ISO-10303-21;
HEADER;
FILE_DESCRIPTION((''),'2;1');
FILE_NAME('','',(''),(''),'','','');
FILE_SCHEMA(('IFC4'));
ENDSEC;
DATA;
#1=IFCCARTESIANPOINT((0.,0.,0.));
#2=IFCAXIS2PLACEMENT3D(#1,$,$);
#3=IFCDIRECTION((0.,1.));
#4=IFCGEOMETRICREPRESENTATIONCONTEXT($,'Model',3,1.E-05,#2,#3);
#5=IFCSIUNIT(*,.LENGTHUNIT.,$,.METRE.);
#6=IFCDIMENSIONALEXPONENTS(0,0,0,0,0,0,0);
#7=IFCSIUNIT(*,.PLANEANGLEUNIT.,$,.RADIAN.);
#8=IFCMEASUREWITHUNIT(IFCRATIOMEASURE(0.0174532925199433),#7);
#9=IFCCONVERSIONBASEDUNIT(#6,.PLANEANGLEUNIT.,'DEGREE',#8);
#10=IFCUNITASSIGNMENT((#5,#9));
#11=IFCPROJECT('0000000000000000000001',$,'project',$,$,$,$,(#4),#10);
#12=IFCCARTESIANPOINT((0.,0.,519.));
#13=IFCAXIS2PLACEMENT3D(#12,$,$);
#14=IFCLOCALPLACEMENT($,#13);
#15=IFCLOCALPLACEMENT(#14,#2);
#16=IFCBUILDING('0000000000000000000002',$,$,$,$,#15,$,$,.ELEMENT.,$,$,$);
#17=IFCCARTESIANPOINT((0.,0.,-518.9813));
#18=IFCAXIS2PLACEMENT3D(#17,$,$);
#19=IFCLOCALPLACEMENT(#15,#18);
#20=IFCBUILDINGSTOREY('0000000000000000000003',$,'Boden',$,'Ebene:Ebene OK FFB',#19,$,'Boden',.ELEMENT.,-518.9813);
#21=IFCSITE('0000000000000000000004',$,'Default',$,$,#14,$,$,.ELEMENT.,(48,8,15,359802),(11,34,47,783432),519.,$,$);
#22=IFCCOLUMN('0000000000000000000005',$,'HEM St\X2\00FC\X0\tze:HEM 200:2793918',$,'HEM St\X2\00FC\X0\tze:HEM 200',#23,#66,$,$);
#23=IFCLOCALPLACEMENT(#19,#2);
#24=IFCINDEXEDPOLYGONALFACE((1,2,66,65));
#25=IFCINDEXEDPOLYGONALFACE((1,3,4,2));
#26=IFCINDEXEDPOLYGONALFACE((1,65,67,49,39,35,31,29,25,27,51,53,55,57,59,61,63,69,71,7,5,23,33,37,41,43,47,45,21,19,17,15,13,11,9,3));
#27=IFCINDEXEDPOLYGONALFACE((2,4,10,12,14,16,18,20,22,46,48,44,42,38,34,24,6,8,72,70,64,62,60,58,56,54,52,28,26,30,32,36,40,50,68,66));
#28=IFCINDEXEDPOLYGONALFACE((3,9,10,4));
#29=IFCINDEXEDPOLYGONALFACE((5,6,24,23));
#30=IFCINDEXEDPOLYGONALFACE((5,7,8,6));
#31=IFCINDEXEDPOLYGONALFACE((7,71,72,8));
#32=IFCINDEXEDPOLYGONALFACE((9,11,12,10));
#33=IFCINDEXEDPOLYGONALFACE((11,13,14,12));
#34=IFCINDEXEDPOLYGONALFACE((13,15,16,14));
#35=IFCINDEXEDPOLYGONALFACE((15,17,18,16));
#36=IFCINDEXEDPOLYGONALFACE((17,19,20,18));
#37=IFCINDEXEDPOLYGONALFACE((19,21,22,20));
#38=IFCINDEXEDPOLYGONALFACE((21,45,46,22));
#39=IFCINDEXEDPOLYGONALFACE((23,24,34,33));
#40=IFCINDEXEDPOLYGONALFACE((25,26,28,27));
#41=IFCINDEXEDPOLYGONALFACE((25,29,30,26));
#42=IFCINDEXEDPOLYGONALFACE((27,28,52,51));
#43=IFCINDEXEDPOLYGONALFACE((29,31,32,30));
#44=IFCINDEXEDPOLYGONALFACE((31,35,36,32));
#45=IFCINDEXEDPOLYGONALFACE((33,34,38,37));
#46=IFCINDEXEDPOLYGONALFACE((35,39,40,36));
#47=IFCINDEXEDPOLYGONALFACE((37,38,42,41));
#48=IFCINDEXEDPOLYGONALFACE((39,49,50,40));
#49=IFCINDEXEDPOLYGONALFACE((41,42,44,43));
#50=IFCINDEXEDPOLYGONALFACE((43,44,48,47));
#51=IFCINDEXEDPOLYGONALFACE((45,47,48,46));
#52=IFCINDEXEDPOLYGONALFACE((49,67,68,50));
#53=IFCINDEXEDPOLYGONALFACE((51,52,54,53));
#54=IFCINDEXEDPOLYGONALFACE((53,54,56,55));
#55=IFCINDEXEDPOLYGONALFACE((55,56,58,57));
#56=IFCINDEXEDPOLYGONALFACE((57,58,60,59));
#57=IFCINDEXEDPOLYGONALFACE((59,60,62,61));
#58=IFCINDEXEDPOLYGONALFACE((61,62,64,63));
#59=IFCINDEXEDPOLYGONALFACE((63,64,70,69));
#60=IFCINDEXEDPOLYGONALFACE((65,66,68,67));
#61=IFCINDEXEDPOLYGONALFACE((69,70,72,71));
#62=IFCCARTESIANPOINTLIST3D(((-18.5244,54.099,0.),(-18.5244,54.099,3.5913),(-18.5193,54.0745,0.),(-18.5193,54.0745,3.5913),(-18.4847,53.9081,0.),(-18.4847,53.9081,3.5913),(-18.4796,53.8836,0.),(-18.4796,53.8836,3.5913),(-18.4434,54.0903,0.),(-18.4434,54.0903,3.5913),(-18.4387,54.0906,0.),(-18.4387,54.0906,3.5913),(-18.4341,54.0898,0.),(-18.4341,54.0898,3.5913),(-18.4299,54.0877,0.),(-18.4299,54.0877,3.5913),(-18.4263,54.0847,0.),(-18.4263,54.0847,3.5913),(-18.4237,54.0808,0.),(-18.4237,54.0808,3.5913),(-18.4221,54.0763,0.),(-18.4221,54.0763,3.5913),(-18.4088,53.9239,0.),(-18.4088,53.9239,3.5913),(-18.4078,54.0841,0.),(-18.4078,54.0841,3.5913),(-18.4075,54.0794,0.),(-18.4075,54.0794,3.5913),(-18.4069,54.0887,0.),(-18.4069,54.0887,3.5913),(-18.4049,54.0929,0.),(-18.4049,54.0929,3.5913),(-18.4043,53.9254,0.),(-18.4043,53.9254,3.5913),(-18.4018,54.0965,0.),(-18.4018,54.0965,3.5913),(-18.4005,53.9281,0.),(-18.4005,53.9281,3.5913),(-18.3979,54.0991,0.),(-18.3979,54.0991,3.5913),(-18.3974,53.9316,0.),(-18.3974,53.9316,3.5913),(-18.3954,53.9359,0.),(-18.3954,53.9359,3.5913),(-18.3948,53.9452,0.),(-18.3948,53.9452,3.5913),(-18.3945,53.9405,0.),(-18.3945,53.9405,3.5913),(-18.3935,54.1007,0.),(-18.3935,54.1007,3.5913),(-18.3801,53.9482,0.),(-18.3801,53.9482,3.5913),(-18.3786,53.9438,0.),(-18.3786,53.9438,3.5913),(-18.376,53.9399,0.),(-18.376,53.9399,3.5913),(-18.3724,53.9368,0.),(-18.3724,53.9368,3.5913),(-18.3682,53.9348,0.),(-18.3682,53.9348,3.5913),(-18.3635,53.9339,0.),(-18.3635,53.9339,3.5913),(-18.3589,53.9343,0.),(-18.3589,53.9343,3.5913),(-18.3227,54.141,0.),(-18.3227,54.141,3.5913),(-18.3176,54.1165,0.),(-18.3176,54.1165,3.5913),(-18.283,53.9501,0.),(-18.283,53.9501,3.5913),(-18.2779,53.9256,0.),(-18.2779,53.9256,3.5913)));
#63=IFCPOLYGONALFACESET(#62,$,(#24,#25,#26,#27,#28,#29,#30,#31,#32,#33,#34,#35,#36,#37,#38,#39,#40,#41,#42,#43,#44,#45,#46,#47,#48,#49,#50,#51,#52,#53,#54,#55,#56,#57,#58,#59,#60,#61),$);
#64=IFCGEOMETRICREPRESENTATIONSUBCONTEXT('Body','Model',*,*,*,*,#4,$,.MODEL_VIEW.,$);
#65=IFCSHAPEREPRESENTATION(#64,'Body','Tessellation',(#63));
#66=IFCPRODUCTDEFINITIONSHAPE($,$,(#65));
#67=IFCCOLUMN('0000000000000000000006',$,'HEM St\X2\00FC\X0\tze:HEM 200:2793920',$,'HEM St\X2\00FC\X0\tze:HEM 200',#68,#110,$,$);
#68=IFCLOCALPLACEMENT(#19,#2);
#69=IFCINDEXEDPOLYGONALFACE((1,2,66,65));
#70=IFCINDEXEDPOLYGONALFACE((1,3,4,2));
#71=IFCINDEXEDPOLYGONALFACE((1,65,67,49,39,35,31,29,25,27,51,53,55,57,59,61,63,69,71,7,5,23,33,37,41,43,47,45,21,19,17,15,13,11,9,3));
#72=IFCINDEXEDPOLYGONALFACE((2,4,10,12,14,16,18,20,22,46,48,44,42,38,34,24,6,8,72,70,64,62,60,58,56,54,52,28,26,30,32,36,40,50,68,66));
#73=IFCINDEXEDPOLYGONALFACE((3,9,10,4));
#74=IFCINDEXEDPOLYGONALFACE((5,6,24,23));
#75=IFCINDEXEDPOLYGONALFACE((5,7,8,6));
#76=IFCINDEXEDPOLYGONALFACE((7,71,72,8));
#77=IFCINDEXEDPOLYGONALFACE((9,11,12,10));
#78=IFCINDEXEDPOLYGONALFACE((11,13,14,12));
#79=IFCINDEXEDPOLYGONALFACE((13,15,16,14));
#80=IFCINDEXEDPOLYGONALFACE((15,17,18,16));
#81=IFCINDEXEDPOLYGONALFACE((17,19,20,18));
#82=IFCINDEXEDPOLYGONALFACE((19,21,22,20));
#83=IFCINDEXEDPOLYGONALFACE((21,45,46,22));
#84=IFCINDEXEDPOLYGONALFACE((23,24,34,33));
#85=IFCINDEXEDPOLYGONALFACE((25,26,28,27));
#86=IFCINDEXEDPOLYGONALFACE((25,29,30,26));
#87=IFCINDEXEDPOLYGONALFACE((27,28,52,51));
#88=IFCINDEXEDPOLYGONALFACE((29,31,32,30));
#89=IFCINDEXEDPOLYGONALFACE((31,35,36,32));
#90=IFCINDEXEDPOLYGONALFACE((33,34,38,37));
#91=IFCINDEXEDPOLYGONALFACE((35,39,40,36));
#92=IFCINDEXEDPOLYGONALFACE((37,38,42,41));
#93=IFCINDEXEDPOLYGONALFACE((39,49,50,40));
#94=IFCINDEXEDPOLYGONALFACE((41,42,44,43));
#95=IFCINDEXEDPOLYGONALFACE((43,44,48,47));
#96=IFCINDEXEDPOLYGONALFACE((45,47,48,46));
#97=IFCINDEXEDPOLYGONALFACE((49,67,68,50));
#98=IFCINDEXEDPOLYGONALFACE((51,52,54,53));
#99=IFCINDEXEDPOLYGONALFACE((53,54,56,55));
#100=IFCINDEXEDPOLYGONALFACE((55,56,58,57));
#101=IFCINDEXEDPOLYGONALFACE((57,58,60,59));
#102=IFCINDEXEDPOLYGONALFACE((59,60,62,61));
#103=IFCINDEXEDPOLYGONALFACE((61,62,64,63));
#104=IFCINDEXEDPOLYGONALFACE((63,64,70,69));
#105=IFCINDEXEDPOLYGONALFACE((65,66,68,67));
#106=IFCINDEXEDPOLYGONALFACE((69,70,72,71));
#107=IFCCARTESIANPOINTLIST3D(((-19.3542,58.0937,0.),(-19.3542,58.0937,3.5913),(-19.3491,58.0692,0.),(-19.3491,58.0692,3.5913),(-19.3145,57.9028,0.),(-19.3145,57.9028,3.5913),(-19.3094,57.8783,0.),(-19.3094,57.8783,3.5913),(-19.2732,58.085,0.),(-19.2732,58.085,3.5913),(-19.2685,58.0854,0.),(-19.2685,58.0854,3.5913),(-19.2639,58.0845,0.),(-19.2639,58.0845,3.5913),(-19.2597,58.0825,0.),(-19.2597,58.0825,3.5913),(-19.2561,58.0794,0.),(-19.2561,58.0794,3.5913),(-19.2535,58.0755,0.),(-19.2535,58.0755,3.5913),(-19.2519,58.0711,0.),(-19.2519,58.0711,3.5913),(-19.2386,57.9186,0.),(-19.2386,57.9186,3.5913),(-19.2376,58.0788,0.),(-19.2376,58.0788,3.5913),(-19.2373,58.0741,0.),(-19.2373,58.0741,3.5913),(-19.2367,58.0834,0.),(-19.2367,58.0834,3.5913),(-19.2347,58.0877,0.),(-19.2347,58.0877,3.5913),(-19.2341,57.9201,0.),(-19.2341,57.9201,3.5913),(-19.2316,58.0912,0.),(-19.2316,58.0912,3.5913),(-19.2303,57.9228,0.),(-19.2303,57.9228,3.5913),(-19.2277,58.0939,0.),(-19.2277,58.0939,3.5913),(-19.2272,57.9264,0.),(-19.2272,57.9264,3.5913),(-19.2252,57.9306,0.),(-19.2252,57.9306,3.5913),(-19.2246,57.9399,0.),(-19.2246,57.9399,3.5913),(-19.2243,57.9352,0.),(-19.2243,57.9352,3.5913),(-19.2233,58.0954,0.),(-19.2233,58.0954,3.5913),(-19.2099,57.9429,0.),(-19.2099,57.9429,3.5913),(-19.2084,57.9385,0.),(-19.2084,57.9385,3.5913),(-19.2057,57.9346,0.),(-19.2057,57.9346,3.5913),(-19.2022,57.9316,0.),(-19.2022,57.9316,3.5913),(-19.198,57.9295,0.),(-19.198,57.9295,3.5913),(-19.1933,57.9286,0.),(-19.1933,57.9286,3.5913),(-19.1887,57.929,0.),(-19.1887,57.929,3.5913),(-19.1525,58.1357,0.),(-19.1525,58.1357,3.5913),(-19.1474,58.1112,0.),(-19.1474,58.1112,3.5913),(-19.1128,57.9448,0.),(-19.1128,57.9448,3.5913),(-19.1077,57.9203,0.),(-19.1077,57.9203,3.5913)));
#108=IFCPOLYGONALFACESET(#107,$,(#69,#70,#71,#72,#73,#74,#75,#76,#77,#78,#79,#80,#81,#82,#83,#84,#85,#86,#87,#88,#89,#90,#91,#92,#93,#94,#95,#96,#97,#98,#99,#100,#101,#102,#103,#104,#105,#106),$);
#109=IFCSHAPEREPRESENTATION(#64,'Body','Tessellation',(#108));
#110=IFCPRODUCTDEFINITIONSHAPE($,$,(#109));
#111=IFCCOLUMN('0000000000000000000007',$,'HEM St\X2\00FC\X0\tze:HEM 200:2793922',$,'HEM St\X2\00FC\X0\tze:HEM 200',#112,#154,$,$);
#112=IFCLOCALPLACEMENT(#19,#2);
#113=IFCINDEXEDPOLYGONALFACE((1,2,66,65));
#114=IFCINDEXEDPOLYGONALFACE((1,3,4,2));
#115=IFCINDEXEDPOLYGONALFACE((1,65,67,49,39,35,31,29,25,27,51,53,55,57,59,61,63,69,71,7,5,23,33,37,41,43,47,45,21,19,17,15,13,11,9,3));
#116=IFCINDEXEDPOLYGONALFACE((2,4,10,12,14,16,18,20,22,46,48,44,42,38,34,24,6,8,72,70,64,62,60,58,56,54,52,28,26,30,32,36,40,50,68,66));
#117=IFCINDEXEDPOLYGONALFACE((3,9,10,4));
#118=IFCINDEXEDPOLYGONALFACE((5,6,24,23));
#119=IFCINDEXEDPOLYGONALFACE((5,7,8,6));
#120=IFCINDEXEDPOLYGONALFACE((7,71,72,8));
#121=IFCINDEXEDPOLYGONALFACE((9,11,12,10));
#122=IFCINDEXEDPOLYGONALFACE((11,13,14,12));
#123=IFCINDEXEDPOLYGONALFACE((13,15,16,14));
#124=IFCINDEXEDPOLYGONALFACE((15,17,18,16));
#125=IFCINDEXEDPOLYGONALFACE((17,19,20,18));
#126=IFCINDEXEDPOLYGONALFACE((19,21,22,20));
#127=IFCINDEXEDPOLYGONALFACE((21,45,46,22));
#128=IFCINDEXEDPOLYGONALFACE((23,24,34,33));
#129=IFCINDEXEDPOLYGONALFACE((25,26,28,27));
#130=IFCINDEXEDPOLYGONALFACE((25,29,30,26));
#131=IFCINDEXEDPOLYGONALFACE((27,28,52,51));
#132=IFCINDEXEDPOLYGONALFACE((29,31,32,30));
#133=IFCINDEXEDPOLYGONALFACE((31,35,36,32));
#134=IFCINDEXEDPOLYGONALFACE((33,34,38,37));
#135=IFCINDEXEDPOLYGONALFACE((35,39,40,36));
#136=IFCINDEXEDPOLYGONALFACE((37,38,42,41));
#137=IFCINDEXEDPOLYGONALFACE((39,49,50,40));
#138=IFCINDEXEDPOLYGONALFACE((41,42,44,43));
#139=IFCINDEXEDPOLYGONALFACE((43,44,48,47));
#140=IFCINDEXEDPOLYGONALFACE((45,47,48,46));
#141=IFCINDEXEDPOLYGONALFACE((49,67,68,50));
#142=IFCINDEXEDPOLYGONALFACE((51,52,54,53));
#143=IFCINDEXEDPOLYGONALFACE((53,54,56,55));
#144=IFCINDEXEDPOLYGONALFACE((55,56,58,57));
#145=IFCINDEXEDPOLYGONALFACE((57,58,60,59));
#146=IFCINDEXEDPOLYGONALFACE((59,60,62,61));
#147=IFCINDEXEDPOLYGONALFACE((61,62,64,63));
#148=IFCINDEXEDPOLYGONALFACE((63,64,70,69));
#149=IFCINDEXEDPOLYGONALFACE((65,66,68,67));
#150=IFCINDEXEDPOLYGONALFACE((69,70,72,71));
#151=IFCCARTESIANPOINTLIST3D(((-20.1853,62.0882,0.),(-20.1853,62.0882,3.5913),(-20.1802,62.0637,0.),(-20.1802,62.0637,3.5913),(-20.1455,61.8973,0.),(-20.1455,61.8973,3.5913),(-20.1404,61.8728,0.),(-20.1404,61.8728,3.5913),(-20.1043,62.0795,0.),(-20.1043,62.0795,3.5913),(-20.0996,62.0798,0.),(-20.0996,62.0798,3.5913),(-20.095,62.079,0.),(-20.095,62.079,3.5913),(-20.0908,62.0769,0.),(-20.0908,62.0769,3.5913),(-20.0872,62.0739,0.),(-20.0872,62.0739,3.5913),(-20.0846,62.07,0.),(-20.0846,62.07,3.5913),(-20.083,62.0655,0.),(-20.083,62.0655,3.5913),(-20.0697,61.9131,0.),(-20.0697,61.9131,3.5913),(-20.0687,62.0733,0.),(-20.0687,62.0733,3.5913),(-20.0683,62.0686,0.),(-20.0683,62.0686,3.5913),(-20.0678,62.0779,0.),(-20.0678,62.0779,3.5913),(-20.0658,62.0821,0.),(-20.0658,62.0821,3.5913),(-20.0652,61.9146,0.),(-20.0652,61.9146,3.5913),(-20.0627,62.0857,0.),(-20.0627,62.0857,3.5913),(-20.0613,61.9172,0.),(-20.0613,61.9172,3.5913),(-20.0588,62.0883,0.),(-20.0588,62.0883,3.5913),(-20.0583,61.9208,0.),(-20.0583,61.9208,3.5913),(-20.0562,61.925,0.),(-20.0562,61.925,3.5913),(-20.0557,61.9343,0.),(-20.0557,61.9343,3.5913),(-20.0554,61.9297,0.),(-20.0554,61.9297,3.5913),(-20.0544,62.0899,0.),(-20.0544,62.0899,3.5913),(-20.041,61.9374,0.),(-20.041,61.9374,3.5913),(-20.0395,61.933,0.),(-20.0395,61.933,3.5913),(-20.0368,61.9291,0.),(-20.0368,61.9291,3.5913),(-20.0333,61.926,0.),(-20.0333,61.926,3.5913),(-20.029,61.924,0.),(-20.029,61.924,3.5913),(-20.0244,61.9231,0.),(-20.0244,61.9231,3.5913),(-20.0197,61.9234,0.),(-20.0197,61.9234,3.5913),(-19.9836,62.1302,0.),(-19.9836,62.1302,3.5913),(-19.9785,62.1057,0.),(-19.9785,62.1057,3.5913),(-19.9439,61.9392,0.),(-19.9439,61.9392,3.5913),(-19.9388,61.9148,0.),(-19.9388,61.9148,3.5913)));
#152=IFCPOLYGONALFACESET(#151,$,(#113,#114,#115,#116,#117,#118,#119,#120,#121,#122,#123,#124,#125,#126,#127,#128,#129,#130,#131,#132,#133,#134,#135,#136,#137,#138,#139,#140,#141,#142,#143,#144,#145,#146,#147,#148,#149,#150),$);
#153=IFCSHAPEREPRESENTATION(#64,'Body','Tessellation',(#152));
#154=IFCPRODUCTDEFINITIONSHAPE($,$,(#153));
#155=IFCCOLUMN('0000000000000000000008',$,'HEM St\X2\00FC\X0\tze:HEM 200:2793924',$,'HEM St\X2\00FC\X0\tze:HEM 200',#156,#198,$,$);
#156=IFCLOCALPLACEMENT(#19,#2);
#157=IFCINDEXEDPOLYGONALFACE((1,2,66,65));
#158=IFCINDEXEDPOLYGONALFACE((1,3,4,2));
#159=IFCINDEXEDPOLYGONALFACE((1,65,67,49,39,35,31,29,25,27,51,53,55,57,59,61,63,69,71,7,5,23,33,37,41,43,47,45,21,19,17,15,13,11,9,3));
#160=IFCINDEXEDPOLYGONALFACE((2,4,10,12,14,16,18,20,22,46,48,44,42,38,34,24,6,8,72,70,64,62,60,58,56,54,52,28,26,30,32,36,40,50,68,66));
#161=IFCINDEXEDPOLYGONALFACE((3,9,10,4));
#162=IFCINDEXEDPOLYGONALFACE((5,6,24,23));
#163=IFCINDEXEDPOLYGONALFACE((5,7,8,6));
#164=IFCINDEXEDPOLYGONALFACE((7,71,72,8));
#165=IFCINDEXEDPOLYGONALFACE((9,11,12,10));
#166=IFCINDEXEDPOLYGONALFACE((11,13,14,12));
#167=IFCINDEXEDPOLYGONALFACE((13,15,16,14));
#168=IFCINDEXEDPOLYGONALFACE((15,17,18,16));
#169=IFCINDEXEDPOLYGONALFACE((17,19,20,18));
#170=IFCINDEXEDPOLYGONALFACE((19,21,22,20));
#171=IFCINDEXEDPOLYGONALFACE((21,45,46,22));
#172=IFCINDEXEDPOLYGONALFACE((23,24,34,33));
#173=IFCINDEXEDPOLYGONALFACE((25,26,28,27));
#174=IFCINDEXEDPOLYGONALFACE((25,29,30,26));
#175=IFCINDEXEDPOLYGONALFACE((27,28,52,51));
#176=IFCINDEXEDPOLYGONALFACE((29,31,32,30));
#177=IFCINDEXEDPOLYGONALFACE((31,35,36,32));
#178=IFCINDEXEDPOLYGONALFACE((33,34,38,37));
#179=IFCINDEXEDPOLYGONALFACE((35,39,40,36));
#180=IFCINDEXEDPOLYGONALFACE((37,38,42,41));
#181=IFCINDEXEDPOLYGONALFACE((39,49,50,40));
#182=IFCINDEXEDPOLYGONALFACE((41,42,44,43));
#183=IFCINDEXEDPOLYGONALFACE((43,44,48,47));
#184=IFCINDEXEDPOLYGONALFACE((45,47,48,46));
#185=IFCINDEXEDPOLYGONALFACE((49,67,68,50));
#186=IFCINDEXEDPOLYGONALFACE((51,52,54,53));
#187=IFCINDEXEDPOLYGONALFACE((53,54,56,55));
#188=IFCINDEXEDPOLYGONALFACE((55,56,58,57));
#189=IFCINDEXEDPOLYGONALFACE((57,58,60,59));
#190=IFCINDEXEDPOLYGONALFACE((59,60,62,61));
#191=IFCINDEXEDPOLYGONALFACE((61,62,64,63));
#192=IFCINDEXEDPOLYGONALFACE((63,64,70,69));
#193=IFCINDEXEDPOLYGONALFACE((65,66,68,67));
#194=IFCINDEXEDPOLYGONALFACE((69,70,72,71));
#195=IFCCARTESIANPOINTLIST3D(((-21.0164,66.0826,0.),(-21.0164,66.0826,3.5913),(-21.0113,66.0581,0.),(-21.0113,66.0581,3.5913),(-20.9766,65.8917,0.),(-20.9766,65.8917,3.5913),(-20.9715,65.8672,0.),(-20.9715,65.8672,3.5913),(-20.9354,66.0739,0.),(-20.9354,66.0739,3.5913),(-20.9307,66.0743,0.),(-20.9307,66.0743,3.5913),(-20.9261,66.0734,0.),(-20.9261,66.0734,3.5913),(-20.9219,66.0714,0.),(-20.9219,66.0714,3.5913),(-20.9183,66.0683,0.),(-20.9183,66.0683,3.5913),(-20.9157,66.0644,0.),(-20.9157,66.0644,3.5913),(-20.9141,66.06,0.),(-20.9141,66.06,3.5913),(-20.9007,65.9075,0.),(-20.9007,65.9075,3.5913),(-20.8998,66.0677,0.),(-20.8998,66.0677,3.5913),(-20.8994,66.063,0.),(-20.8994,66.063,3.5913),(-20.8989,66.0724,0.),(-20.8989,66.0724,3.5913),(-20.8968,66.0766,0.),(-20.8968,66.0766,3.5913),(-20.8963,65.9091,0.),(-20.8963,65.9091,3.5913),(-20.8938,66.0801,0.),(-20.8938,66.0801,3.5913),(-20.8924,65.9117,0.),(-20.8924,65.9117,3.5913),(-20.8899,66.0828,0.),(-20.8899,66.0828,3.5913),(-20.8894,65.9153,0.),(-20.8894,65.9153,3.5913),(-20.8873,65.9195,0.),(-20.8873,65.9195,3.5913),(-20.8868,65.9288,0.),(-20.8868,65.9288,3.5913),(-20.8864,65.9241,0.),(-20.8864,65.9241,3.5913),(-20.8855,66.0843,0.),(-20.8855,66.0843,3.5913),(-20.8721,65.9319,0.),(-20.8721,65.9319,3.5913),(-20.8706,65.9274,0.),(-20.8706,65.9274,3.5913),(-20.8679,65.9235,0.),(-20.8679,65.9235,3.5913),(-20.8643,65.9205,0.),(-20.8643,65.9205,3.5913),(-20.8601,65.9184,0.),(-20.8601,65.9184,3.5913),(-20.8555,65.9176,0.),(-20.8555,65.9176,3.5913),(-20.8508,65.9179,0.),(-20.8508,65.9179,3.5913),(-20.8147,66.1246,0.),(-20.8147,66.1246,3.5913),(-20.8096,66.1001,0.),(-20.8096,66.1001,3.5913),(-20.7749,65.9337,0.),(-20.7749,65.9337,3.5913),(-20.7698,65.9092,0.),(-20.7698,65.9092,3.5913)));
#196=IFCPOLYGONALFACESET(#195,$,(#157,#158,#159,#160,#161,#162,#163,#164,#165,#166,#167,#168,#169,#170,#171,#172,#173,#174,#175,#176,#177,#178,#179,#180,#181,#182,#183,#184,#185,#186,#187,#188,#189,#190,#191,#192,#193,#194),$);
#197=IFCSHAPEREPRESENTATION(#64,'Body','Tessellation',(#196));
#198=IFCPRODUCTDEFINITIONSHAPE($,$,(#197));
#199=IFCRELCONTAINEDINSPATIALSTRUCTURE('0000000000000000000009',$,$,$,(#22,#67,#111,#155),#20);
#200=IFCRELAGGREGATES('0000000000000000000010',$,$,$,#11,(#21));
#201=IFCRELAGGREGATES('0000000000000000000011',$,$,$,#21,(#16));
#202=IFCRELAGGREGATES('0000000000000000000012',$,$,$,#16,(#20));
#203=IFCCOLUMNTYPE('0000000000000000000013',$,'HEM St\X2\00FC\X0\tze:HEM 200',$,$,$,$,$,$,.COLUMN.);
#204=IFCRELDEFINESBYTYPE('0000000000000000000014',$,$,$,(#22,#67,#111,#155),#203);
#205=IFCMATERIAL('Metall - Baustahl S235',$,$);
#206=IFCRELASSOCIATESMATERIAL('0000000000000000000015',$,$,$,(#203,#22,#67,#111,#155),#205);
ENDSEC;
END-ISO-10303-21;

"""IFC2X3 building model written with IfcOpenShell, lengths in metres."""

from ifc_helpers import new_model, entity, si_unit, converted_unit, direction, frame, frame_2d, origin, place, context, subcontext, project, spatial, polyline, circle_curve, parameter, trimmed, segment, composite_curve, outline, extrude, source, transform, mapped, material, type_object, type_shapes, element, save


model = new_model("IFC2X3")

# Units and contexts
model_context = context("Model", 3, precision=1e-05, world=origin(), true_north=direction((0.0, 1.0)))
body_context = subcontext(model_context, "Body", "Model", "MODEL_VIEW")
ifc_project = project(units=[si_unit("LENGTHUNIT", "METRE"), converted_unit("PLANEANGLEUNIT", "DEGREE", entity("IfcRatioMeasure", 0.0174532925199433), si_unit("PLANEANGLEUNIT", "RADIAN"), dimensions=[0, 0, 0, 0, 0, 0, 0])], contexts=[model_context])

# Site, building, storey
site_placement = place(None, frame((0.0, 0.0, 519.0)))
site = spatial("IfcSite", under=ifc_project, at=site_placement, Name="Default", CompositionType="ELEMENT", RefLatitude=(48, 8, 15, 359802), RefLongitude=(11, 34, 47, 783432), RefElevation=519.0)
building_placement = place(site_placement, origin())
building = spatial("IfcBuilding", under=site, at=building_placement, CompositionType="ELEMENT")
storey_placement = place(building_placement, frame((0.0, 0.0, -518.9813)))
storey = spatial("IfcBuildingStorey", under=building, at=storey_placement, Name="Boden", ObjectType="Ebene:Ebene OK FFB", LongName="Boden", CompositionType="ELEMENT", Elevation=-518.9813)

# Columns
ifc_material = material(Name="Metall - Baustahl S235")
column_type = type_object("IfcColumnType", Name="HEM Stütze:HEM 200", PredefinedType="COLUMN", material=ifc_material)
shared_shape = source(origin(), body_context, "Body", "SweptSolid", [
    extrude(outline(composite_curve([segment(polyline([(0.085, -0.103), (0.11, -0.103)]), True, "CONTINUOUS"), segment(polyline([(0.11, -0.103), (0.11, 0.103)]), True, "CONTINUOUS"), segment(polyline([(0.11, 0.103), (0.085, 0.103)]), True, "CONTINUOUS"), segment(polyline([(0.085, 0.103), (0.085, 0.0255)]), True, "CONTINUOUS"), segment(trimmed(circle_curve(frame_2d((0.067, 0.0255), x_axis=(1.0, 0.0)), 0.018), [parameter(270.0)], [parameter(0.0)], True, "PARAMETER"), False, "CONTINUOUS"), segment(polyline([(0.067, 0.0075), (-0.067, 0.0075)]), True, "CONTINUOUS"), segment(trimmed(circle_curve(frame_2d((-0.067, 0.0255), x_axis=(0.0, -1.0)), 0.018), [parameter(270.0)], [parameter(0.0)], True, "PARAMETER"), False, "CONTINUOUS"), segment(polyline([(-0.085, 0.0255), (-0.085, 0.103)]), True, "CONTINUOUS"), segment(polyline([(-0.085, 0.103), (-0.11, 0.103)]), True, "CONTINUOUS"), segment(polyline([(-0.11, 0.103), (-0.11, -0.103)]), True, "CONTINUOUS"), segment(polyline([(-0.11, -0.103), (-0.085, -0.103)]), True, "CONTINUOUS"), segment(polyline([(-0.085, -0.103), (-0.085, -0.0255)]), True, "CONTINUOUS"), segment(trimmed(circle_curve(frame_2d((-0.067, -0.0255), x_axis=(-1.0, 0.0)), 0.018), [parameter(270.0)], [parameter(0.0)], True, "PARAMETER"), False, "CONTINUOUS"), segment(polyline([(-0.067, -0.0075), (0.067, -0.0075)]), True, "CONTINUOUS"), segment(trimmed(circle_curve(frame_2d((0.067, -0.0255), x_axis=(0.0, 1.0)), 0.018), [parameter(270.0)], [parameter(0.0)], True, "PARAMETER"), False, "CONTINUOUS"), segment(polyline([(0.085, -0.0255), (0.085, -0.103)]), True, "CONTINUOUS")], self_intersect=False)), frame((0.0, 0.0, -518.9813), z_axis=(0.0, 0.0, 1.0), x_axis=(0.0, -1.0, 0.0)), (0.0, 0.0, 1.0), 3.5913),
])
type_shapes(column_type, [shared_shape])
for number, where, z_axis, x_axis, name in (
    (1, (-18.4011, 54.0123, 518.9813), (0.0, 0.0, 1.0), (0.979008, 0.20382, 0.0), "HEM Stütze:HEM 200:2793918"),
    (2, (-19.2309, 58.007, 518.9813), (0.0, 0.0, 1.0), (0.979008, 0.20382, 0.0), "HEM Stütze:HEM 200:2793920"),
    (3, (-20.062, 62.0015, 518.9813), (0.0, 0.0, 1.0), (0.979008, 0.20382, 0.0), "HEM Stütze:HEM 200:2793922"),
    (4, (-20.8931, 65.9959, 518.9813), (0.0, 0.0, 1.0), (0.979008, 0.20382, 0.0), "HEM Stütze:HEM 200:2793924"),
):
    element("IfcColumn", number, at=place(storey_placement, frame(where, z_axis=z_axis, x_axis=x_axis)), inside=storey, type_object=column_type, material=ifc_material, Name=name, ObjectType="HEM Stütze:HEM 200", context=body_context, shape_type="MappedRepresentation", body=[
        mapped(shared_shape, transform((0.0, 0.0, 0.0), scale=1.0)),
    ])

save(model, "model.ifc")
